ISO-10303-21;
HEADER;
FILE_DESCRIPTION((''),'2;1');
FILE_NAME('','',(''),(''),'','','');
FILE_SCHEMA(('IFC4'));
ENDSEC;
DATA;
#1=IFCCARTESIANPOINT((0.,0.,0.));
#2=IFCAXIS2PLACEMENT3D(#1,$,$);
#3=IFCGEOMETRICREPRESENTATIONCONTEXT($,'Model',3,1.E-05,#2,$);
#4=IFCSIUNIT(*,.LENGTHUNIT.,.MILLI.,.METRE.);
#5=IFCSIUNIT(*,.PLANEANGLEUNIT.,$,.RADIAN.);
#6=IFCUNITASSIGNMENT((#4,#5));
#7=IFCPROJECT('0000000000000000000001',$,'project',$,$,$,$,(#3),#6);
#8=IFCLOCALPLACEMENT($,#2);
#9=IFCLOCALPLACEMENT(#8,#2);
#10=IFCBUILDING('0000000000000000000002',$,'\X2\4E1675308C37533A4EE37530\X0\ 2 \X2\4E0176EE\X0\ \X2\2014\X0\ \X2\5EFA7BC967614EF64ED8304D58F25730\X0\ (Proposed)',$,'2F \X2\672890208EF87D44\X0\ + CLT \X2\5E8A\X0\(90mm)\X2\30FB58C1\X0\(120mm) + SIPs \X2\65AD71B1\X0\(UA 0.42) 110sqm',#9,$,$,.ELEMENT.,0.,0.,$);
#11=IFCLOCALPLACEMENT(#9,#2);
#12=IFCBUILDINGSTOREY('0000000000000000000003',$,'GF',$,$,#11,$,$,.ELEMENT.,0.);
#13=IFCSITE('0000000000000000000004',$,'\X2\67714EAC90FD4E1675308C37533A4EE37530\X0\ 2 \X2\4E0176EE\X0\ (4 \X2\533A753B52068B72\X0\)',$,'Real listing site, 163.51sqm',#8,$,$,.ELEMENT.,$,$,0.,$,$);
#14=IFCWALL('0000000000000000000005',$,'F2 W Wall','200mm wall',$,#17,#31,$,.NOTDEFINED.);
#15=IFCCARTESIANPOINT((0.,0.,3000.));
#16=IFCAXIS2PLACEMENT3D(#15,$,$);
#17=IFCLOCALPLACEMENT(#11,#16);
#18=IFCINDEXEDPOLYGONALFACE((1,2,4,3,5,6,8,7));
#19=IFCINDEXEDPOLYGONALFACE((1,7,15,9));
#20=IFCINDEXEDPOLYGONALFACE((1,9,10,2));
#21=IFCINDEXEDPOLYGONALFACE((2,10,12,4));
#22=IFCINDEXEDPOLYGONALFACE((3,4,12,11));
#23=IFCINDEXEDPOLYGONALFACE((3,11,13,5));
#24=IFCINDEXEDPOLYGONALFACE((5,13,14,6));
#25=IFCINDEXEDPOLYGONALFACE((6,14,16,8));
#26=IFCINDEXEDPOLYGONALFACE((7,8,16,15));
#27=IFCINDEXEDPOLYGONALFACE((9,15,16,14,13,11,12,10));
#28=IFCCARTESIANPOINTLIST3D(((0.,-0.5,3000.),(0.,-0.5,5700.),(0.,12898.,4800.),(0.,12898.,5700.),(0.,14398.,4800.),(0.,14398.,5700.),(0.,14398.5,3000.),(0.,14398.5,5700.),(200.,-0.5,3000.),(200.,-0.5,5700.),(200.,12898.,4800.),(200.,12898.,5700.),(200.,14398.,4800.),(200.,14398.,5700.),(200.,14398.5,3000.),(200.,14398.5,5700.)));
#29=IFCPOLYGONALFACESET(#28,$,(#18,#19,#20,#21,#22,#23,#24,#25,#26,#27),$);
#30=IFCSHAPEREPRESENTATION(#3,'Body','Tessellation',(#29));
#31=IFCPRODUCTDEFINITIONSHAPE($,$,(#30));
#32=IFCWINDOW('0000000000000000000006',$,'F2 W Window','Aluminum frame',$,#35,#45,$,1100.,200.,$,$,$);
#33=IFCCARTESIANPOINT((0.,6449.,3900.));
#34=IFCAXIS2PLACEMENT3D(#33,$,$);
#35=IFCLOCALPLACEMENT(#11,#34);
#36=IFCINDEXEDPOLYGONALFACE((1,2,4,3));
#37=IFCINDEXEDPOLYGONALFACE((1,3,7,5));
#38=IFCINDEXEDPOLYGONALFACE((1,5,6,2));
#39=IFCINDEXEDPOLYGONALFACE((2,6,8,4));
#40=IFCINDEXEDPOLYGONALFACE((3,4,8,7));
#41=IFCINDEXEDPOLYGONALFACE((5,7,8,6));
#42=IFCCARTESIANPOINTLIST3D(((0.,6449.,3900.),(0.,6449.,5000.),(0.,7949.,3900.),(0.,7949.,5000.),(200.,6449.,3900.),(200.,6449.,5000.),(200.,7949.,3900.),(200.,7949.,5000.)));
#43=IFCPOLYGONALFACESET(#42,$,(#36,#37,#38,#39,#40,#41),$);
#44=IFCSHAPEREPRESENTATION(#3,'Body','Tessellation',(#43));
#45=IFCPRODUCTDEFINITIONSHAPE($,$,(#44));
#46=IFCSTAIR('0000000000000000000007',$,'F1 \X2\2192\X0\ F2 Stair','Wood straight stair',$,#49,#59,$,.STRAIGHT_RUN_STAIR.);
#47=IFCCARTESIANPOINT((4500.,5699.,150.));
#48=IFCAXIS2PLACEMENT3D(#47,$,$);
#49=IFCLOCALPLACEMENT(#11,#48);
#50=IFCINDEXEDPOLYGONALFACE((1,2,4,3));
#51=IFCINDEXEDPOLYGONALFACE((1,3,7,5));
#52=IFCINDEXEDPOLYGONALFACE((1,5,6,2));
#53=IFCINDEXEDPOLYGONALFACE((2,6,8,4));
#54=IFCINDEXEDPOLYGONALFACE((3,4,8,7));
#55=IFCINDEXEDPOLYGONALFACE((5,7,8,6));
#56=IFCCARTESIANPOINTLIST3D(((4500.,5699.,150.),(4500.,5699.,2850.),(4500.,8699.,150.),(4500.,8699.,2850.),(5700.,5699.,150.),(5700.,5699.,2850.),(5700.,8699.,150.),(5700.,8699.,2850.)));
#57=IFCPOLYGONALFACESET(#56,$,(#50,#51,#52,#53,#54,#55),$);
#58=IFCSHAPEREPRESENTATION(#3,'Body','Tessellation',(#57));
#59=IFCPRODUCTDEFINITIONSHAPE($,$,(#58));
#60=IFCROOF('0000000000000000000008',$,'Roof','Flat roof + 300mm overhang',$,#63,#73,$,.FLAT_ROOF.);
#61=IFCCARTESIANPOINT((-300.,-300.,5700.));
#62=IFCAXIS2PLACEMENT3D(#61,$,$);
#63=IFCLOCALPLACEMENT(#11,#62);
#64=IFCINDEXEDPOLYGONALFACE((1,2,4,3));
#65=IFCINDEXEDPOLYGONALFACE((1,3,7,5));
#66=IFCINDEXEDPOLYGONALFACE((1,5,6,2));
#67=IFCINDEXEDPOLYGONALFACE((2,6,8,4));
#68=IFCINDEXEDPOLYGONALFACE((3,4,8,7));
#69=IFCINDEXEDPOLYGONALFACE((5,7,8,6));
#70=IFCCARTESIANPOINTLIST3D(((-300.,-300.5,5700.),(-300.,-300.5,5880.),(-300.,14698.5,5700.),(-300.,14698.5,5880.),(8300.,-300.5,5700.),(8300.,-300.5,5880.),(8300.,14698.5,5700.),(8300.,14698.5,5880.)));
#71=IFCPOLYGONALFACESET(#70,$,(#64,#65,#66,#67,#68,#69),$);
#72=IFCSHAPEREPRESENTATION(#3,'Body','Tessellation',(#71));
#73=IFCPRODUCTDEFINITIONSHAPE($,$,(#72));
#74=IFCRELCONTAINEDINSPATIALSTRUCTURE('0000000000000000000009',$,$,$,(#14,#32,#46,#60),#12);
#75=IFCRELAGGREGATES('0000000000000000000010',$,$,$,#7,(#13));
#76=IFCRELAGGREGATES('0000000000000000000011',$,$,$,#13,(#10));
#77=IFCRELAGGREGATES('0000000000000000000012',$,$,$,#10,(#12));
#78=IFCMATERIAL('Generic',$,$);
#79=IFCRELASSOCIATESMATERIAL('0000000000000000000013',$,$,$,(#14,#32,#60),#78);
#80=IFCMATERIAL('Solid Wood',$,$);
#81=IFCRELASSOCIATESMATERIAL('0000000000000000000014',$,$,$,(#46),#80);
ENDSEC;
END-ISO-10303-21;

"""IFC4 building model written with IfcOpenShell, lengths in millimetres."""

from ifc_helpers import new_model, si_unit, frame, frame_2d, origin, place, context, project, spatial, rectangle, extrude, material, element, fill, save


model = new_model("IFC4")

# Units and contexts
model_context = context("Model", 3, precision=1e-05, world=origin())
ifc_project = project(units=[si_unit("LENGTHUNIT", "METRE", prefix="MILLI"), si_unit("PLANEANGLEUNIT", "RADIAN")], contexts=[model_context])

# Site, building, storey
site_placement = place(None, origin())
site = spatial("IfcSite", under=ifc_project, at=site_placement, Name="東京都世田谷区代田 2 丁目 (4 区画分譲)", ObjectType="Real listing site, 163.51sqm", CompositionType="ELEMENT", RefElevation=0.0)
building_placement = place(site_placement, origin())
building = spatial("IfcBuilding", under=site, at=building_placement, Name="世田谷区代田 2 丁目 — 建築条件付き売地 (Proposed)", ObjectType="2F 木造軸組 + CLT 床(90mm)・壁(120mm) + SIPs 断熱(UA 0.42) 110sqm", CompositionType="ELEMENT", ElevationOfRefHeight=0.0, ElevationOfTerrain=0.0)
storey_placement = place(building_placement, origin())
storey = spatial("IfcBuildingStorey", under=building, at=storey_placement, Name="GF", CompositionType="ELEMENT", Elevation=0.0)

# Shared definitions
ifc_material_1 = material(Name="Solid Wood")

# Shared definitions
ifc_material_2 = material(Name="Generic")

# Wall, opening, window
wall_1_placement = place(storey_placement, frame((0.0, 0.0, 3000.0)))
wall_1 = element("IfcWall", 1, at=wall_1_placement, inside=storey, material=ifc_material_2, Name="F2 W Wall", Description="200mm wall", PredefinedType="NOTDEFINED", context=model_context, shape_type="SweptSolid", body=[
    extrude(rectangle(XDim=200.0, YDim=14399.0, at=frame_2d((100.0, 7199.0))), frame((0.0, 0.0, 3000.0)), (0.0, 0.0, 1.0), 2700.0),
])
opening_1_placement = place(storey_placement, frame((0.0, 6449.0, 3900.0)))
opening_1 = element("IfcOpeningElement", 2, at=opening_1_placement, cuts=wall_1, PredefinedType="NOTDEFINED", context=model_context, shape_type="SweptSolid", body=[
    extrude(rectangle(XDim=200.0, YDim=1500.0, at=frame_2d((100.0, 750.0))), frame((0.0, 6449.0, 3900.0)), (0.0, 0.0, 1.0), 1100.0),
])
window_1_placement = place(storey_placement, frame((0.0, 6449.0, 3900.0)))
window_1 = element("IfcWindow", 3, at=window_1_placement, inside=storey, material=ifc_material_2, Name="F2 W Window", Description="Aluminum frame", OverallHeight=1100.0, OverallWidth=200.0, context=model_context, shape_type="SweptSolid", body=[
    extrude(rectangle(XDim=200.0, YDim=1500.0, at=frame_2d((100.0, 750.0))), frame((0.0, 6449.0, 3900.0)), (0.0, 0.0, 1.0), 1100.0),
])
fill(opening_1, window_1)

# Stair
stair_placement = place(storey_placement, frame((4500.0, 5699.0, 150.0)))
element("IfcStair", 4, at=stair_placement, inside=storey, material=ifc_material_1, Name="F1 → F2 Stair", Description="Wood straight stair", PredefinedType="STRAIGHT_RUN_STAIR", context=model_context, shape_type="SweptSolid", body=[
    extrude(rectangle(XDim=1200.0, YDim=3000.0, at=frame_2d((600.0, 1500.0))), frame((4500.0, 5699.0, 150.0)), (0.0, 0.0, 1.0), 2700.0),
])

# Roof
roof_placement = place(storey_placement, frame((-300.0, -300.0, 5700.0)))
element("IfcRoof", 5, at=roof_placement, inside=storey, material=ifc_material_2, Name="Roof", Description="Flat roof + 300mm overhang", PredefinedType="FLAT_ROOF", context=model_context, shape_type="SweptSolid", body=[
    extrude(rectangle(XDim=8600.0, YDim=14999.0, at=frame_2d((4300.0, 7499.0))), frame((-300.0, -300.0, 5700.0)), (0.0, 0.0, 1.0), 180.0),
])

save(model, "model.ifc")
